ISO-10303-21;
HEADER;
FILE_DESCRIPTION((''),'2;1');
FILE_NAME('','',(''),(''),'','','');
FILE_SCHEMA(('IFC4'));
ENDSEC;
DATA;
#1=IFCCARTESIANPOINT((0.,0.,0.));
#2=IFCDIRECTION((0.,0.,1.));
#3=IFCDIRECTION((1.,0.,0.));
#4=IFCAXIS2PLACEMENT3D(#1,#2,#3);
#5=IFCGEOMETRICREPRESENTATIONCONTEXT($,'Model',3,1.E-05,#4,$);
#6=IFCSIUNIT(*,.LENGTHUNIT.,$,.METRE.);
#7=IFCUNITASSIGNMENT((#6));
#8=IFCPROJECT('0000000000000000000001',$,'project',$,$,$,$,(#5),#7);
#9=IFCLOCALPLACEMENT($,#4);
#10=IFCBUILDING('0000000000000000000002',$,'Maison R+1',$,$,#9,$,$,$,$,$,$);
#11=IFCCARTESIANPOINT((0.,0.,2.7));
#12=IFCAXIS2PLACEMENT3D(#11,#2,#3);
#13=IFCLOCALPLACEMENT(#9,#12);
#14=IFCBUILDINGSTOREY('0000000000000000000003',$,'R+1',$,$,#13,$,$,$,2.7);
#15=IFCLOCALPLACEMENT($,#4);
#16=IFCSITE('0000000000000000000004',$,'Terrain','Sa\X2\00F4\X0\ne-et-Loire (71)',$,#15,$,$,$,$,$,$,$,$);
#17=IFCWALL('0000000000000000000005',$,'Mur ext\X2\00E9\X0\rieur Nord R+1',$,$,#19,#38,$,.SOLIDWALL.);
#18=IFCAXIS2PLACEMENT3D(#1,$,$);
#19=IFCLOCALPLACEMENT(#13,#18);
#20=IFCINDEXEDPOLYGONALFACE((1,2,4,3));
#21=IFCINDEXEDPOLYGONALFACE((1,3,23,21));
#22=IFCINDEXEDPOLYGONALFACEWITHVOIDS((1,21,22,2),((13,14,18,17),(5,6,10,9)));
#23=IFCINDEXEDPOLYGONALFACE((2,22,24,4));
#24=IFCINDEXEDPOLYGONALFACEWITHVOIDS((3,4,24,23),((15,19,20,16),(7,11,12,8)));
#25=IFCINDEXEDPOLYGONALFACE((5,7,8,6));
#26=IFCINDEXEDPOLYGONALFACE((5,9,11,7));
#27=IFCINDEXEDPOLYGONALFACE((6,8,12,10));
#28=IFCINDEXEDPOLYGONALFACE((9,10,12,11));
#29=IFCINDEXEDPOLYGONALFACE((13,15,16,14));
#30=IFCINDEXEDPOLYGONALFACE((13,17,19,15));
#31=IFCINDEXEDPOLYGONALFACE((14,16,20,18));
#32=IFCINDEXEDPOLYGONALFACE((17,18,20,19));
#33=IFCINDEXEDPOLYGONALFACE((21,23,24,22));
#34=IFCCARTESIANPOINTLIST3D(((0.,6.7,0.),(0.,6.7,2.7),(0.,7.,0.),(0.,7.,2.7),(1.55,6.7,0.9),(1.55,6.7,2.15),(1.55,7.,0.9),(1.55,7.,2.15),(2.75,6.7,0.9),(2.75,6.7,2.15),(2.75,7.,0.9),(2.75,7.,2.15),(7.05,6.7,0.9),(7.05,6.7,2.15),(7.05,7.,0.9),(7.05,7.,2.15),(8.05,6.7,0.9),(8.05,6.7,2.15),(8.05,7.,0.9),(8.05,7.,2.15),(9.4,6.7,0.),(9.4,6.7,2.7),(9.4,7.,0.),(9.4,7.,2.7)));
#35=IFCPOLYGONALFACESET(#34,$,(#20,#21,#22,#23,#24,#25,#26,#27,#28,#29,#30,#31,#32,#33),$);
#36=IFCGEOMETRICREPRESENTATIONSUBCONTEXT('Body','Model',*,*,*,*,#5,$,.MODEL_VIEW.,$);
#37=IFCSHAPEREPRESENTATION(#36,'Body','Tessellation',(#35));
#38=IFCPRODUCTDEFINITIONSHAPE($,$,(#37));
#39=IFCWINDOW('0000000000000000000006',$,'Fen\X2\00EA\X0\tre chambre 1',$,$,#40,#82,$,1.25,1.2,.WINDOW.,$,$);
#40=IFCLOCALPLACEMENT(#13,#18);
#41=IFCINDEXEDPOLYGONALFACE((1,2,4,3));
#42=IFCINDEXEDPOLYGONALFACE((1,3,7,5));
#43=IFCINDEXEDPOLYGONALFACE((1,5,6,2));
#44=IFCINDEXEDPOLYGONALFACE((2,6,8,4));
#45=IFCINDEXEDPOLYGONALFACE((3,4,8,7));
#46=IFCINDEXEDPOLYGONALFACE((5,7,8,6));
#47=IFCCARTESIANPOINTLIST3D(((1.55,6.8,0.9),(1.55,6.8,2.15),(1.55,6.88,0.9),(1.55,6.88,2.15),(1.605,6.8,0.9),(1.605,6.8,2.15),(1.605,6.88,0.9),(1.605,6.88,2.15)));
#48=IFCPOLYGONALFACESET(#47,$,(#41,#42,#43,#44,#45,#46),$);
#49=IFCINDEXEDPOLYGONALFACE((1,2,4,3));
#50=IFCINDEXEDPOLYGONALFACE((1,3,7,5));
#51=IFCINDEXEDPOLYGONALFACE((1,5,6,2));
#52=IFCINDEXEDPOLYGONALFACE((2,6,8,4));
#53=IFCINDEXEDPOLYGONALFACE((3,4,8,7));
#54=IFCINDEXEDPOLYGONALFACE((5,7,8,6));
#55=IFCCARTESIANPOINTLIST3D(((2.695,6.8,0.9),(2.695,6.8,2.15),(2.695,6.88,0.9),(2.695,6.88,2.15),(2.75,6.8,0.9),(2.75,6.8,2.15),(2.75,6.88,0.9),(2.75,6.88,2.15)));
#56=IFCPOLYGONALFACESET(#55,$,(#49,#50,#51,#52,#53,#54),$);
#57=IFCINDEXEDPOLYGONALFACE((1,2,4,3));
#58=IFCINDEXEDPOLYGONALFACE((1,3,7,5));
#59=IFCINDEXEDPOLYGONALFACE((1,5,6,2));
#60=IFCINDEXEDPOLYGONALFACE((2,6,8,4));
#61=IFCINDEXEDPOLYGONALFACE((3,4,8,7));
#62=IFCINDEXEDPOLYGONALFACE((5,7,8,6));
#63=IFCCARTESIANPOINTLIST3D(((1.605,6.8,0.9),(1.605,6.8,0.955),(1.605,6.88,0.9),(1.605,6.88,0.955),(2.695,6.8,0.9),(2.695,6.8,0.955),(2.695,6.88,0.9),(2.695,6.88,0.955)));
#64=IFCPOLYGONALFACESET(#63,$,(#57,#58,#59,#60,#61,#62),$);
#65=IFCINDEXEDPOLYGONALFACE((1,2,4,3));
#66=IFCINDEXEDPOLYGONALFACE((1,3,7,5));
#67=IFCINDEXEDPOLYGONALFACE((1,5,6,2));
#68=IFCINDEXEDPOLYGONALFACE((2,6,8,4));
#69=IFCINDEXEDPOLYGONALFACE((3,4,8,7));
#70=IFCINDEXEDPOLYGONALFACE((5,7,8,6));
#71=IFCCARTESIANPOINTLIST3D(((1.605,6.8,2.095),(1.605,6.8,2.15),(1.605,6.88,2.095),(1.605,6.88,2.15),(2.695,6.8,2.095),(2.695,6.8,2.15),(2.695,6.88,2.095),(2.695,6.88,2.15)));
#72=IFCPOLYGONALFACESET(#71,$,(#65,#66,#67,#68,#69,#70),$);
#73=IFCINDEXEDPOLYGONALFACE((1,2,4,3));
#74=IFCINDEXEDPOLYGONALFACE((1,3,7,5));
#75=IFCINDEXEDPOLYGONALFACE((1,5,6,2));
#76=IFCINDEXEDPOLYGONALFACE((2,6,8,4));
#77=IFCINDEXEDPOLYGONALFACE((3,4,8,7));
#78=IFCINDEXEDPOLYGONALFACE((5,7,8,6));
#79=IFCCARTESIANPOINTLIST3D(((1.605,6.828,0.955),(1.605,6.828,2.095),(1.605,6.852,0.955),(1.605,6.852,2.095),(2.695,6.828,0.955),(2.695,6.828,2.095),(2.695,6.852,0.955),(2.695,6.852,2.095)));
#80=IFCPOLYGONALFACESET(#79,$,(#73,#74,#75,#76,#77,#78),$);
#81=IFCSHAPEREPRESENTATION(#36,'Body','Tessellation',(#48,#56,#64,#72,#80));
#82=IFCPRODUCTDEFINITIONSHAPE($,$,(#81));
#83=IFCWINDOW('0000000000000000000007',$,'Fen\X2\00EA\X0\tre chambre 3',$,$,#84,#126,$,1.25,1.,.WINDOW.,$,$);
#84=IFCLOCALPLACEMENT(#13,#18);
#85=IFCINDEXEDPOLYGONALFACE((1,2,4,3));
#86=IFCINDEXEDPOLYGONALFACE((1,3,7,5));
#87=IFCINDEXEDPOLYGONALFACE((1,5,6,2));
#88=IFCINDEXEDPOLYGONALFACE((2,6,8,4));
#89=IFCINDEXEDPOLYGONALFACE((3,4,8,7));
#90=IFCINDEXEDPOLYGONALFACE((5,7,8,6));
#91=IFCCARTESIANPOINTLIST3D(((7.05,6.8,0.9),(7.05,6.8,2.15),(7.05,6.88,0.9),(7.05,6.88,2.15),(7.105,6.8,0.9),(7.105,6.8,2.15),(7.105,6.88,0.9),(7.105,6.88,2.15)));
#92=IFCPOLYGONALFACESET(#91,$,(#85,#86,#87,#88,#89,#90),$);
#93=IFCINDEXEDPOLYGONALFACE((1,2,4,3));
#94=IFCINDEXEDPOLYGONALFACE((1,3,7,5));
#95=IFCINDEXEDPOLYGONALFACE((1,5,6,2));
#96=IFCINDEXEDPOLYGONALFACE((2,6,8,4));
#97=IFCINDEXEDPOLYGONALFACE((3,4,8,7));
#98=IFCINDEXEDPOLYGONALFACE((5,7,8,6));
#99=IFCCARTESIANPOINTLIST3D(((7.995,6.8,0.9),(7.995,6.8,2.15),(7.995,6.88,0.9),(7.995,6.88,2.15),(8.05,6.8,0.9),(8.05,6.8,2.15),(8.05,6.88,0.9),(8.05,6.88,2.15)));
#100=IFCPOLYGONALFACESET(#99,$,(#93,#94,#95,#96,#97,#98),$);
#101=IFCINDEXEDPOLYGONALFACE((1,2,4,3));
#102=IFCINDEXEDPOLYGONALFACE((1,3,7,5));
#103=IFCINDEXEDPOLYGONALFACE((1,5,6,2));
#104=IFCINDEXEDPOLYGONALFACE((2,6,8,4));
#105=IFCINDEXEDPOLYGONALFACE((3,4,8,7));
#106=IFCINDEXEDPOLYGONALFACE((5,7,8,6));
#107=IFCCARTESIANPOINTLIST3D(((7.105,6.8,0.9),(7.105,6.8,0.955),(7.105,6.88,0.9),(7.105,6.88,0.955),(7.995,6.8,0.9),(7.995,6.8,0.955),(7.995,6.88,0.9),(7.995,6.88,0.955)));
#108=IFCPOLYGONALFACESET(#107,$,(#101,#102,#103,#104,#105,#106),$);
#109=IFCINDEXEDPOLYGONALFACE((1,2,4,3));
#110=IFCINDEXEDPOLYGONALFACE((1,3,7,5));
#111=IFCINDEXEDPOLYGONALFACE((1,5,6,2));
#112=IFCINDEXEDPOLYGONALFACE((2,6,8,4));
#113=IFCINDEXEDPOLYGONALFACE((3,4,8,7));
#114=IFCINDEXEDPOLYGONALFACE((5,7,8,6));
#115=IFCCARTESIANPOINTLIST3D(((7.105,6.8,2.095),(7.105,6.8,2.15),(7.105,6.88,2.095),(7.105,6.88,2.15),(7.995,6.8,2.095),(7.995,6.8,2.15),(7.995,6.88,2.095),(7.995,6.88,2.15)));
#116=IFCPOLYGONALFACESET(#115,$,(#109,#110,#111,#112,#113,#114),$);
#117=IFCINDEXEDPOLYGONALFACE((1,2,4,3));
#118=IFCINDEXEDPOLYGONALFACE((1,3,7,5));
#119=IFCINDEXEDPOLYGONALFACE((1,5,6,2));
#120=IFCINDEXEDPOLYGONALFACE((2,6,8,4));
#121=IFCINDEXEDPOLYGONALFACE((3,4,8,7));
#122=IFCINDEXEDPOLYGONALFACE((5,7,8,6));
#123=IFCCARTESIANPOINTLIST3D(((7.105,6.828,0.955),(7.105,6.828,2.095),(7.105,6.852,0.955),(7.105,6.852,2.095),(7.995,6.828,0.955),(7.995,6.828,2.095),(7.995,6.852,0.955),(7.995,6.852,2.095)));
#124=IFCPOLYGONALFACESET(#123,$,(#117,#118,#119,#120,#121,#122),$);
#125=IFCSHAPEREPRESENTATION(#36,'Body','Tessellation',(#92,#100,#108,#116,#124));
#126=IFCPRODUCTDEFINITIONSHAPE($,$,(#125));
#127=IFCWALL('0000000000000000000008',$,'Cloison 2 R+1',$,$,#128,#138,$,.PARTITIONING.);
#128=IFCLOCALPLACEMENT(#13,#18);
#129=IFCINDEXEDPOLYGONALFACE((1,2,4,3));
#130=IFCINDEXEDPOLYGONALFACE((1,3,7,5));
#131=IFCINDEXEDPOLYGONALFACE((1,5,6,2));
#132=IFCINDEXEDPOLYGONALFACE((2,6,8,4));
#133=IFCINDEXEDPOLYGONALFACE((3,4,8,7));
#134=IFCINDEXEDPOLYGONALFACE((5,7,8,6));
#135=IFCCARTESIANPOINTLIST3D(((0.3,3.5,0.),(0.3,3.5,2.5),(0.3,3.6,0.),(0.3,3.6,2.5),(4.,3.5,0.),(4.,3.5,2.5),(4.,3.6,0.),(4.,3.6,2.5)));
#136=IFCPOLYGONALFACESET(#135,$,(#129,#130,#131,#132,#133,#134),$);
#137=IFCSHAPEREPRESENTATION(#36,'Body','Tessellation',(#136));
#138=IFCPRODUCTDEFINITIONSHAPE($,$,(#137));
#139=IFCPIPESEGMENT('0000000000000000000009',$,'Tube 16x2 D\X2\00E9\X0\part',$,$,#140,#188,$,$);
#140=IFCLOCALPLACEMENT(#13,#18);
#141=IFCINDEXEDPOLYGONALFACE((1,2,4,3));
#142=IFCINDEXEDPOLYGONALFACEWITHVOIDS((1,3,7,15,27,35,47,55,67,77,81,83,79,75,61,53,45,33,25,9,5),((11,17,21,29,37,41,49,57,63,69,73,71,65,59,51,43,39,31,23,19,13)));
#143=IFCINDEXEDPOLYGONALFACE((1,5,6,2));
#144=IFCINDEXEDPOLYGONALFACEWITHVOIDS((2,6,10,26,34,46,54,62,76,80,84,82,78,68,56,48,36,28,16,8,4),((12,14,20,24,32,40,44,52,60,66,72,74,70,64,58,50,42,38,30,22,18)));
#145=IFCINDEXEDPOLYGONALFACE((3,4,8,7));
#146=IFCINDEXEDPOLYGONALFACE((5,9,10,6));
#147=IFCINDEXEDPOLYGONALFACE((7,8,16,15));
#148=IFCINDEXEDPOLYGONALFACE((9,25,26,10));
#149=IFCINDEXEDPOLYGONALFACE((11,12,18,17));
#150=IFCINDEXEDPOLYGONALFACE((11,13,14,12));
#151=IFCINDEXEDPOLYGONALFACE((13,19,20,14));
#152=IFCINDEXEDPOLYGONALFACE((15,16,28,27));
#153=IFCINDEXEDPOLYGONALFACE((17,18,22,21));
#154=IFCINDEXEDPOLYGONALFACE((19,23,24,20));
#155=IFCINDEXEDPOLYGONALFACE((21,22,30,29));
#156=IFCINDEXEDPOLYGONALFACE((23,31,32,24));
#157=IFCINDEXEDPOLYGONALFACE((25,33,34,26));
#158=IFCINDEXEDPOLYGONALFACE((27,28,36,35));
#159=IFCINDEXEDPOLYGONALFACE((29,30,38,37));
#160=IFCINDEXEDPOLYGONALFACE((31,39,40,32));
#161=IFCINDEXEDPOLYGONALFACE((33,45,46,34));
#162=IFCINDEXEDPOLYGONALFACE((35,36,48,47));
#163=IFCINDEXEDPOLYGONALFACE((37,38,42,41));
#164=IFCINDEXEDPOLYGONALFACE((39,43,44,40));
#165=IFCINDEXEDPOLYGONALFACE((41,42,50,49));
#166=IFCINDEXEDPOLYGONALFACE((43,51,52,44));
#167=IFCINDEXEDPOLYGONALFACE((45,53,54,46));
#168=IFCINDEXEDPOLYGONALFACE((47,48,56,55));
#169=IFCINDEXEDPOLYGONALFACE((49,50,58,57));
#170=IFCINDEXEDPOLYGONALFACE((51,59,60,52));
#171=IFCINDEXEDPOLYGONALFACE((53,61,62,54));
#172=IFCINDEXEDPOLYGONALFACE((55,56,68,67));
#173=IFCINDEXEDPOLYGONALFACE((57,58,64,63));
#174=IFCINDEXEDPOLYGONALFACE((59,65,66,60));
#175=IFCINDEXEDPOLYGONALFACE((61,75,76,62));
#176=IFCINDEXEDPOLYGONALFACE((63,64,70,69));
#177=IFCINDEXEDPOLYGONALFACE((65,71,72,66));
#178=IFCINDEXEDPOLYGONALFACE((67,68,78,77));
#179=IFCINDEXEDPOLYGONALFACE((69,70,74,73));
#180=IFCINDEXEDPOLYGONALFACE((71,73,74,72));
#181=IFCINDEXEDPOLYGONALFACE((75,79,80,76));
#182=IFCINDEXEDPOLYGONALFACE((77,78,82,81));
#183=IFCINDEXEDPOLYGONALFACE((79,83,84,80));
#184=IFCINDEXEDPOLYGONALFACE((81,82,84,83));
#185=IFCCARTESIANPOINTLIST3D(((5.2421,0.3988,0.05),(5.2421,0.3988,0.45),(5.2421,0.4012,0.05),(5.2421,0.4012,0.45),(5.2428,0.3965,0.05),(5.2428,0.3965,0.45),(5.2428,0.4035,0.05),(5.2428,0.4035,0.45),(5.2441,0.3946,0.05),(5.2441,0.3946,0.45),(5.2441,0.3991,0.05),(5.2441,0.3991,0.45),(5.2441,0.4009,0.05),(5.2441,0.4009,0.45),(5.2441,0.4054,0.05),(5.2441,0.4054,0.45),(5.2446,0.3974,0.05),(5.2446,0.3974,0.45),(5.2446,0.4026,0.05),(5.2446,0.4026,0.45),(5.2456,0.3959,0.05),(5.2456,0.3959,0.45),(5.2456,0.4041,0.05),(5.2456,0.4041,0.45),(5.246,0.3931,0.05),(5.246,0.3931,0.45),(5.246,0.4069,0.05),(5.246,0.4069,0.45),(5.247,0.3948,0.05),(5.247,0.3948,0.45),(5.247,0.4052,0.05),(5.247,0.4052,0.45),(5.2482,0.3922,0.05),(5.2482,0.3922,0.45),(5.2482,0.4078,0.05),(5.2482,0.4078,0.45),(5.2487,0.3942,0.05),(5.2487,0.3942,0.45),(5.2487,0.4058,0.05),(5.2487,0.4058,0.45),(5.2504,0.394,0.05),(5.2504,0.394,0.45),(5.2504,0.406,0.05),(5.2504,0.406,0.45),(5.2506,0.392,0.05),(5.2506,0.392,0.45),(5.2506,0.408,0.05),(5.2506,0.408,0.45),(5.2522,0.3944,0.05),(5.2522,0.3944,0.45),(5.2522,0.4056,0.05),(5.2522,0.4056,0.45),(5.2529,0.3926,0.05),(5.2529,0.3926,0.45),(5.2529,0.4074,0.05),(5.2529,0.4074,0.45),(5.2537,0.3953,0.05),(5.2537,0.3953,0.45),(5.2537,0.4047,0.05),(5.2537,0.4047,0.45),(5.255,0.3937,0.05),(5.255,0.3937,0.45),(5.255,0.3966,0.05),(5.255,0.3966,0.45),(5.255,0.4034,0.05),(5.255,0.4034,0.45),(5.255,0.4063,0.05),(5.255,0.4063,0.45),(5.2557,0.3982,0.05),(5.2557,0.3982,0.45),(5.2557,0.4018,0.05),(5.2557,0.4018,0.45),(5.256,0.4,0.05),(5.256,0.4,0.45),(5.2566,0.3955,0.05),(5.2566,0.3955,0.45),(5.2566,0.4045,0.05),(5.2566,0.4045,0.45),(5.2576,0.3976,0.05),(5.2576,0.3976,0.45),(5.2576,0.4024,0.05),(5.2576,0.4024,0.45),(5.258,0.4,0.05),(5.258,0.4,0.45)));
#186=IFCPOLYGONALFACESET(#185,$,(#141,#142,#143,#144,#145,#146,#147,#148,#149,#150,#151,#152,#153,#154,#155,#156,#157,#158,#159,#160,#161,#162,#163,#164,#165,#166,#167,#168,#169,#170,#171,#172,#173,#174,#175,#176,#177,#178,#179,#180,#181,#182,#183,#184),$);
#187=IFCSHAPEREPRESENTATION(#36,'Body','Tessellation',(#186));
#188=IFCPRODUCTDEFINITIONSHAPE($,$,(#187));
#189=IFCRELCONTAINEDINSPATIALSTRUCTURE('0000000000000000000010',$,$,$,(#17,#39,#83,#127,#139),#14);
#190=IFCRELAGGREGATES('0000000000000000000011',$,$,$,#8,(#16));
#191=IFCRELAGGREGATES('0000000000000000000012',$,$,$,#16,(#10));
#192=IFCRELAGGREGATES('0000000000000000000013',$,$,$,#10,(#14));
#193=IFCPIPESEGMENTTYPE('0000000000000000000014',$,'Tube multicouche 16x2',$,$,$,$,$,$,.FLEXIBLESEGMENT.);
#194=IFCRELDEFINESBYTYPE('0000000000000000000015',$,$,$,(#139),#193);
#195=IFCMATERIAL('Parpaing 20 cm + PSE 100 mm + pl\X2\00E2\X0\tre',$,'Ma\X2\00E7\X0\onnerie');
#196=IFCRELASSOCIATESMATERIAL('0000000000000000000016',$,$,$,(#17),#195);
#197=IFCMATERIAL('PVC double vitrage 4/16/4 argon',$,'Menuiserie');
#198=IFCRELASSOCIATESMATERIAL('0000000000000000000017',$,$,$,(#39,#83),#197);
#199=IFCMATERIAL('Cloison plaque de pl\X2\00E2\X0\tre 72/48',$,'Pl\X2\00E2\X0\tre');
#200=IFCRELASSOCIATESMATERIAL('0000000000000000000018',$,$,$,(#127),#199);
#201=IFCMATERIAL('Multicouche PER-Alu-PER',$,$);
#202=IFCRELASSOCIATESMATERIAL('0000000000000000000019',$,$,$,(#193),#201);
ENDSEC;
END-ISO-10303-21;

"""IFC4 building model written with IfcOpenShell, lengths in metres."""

from ifc_helpers import new_model, si_unit, frame, frame_2d, origin_with_axes, place, context, subcontext, project, spatial, rectangle, hollow_circle, extrude, material, type_object, element, fill, save


model = new_model("IFC4")

# Units and contexts
model_context = context("Model", 3, precision=1e-05, world=origin_with_axes())
body_context = subcontext(model_context, "Body", "Model", "MODEL_VIEW")
ifc_project = project(units=[si_unit("LENGTHUNIT", "METRE")], contexts=[model_context])

# Site, building, storey
site_placement = place(None, origin_with_axes())
site = spatial("IfcSite", under=ifc_project, at=site_placement, Name="Terrain", Description="Saône-et-Loire (71)")
building_placement = place(None, origin_with_axes())
building = spatial("IfcBuilding", under=site, at=building_placement, Name="Maison R+1")
storey_placement = place(building_placement, frame((0.0, 0.0, 2.7), z_axis=(0.0, 0.0, 1.0), x_axis=(1.0, 0.0, 0.0)))
storey = spatial("IfcBuildingStorey", under=building, at=storey_placement, Name="R+1", Elevation=2.7)

# Wall, openings, windows
ifc_material_1 = material(Name="Parpaing 20 cm + PSE 100 mm + plâtre", Category="Maçonnerie")
wall_1_placement = place(storey_placement, frame((0.0, 6.7, 0.0), z_axis=(0.0, 0.0, 1.0), x_axis=(1.0, 0.0, 0.0)))
wall_1 = element("IfcWall", 1, at=wall_1_placement, inside=storey, material=ifc_material_1, Name="Mur extérieur Nord R+1", PredefinedType="SOLIDWALL", context=body_context, shape_type="SweptSolid", body=[
    extrude(rectangle(XDim=9.4, YDim=0.3, at=frame_2d((4.7, 0.15))), origin_with_axes(), (0.0, 0.0, 1.0), 2.7),
])
opening_1_placement = place(storey_placement, frame((1.55, 6.65, 0.9), z_axis=(0.0, 0.0, 1.0), x_axis=(1.0, 0.0, 0.0)))
opening_1 = element("IfcOpeningElement", 2, at=opening_1_placement, cuts=wall_1, context=body_context, shape_type="SweptSolid", body=[
    extrude(rectangle(XDim=1.2, YDim=0.4, at=frame_2d((0.6, 0.2))), origin_with_axes(), (0.0, 0.0, 1.0), 1.25),
])
opening_2_placement = place(storey_placement, frame((7.05, 6.65, 0.9), z_axis=(0.0, 0.0, 1.0), x_axis=(1.0, 0.0, 0.0)))
opening_2 = element("IfcOpeningElement", 3, at=opening_2_placement, cuts=wall_1, context=body_context, shape_type="SweptSolid", body=[
    extrude(rectangle(XDim=1.0, YDim=0.4, at=frame_2d((0.5, 0.2))), origin_with_axes(), (0.0, 0.0, 1.0), 1.25),
])
ifc_material_2 = material(Name="PVC double vitrage 4/16/4 argon", Category="Menuiserie")
window_1_placement = place(storey_placement, frame((1.55, 6.8, 0.9), z_axis=(0.0, 0.0, 1.0), x_axis=(1.0, 0.0, 0.0)))
window_1 = element("IfcWindow", 4, at=window_1_placement, inside=storey, material=ifc_material_2, Name="Fenêtre chambre 1", OverallHeight=1.25, OverallWidth=1.2, PredefinedType="WINDOW", context=body_context, shape_type="SweptSolid", body=[
    extrude(rectangle(XDim=0.055, YDim=0.08, at=frame_2d((0.0275, 0.04))), origin_with_axes(), (0.0, 0.0, 1.0), 1.25),
    extrude(rectangle(XDim=0.055, YDim=0.08, at=frame_2d((0.0275, 0.04))), frame((1.145, 0.0, 0.0), z_axis=(0.0, 0.0, 1.0), x_axis=(1.0, 0.0, 0.0)), (0.0, 0.0, 1.0), 1.25),
    extrude(rectangle(XDim=1.09, YDim=0.08, at=frame_2d((0.545, 0.04))), frame((0.055, 0.0, 0.0), z_axis=(0.0, 0.0, 1.0), x_axis=(1.0, 0.0, 0.0)), (0.0, 0.0, 1.0), 0.055),
    extrude(rectangle(XDim=1.09, YDim=0.08, at=frame_2d((0.545, 0.04))), frame((0.055, 0.0, 1.195), z_axis=(0.0, 0.0, 1.0), x_axis=(1.0, 0.0, 0.0)), (0.0, 0.0, 1.0), 0.055),
    extrude(rectangle(XDim=1.09, YDim=0.024, at=frame_2d((0.545, 0.012))), frame((0.055, 0.028, 0.055), z_axis=(0.0, 0.0, 1.0), x_axis=(1.0, 0.0, 0.0)), (0.0, 0.0, 1.0), 1.14),
])
fill(opening_1, window_1)
window_2_placement = place(storey_placement, frame((7.05, 6.8, 0.9), z_axis=(0.0, 0.0, 1.0), x_axis=(1.0, 0.0, 0.0)))
window_2 = element("IfcWindow", 5, at=window_2_placement, inside=storey, material=ifc_material_2, Name="Fenêtre chambre 3", OverallHeight=1.25, OverallWidth=1.0, PredefinedType="WINDOW", context=body_context, shape_type="SweptSolid", body=[
    extrude(rectangle(XDim=0.055, YDim=0.08, at=frame_2d((0.0275, 0.04))), origin_with_axes(), (0.0, 0.0, 1.0), 1.25),
    extrude(rectangle(XDim=0.055, YDim=0.08, at=frame_2d((0.0275, 0.04))), frame((0.945, 0.0, 0.0), z_axis=(0.0, 0.0, 1.0), x_axis=(1.0, 0.0, 0.0)), (0.0, 0.0, 1.0), 1.25),
    extrude(rectangle(XDim=0.89, YDim=0.08, at=frame_2d((0.445, 0.04))), frame((0.055, 0.0, 0.0), z_axis=(0.0, 0.0, 1.0), x_axis=(1.0, 0.0, 0.0)), (0.0, 0.0, 1.0), 0.055),
    extrude(rectangle(XDim=0.89, YDim=0.08, at=frame_2d((0.445, 0.04))), frame((0.055, 0.0, 1.195), z_axis=(0.0, 0.0, 1.0), x_axis=(1.0, 0.0, 0.0)), (0.0, 0.0, 1.0), 0.055),
    extrude(rectangle(XDim=0.89, YDim=0.024, at=frame_2d((0.445, 0.012))), frame((0.055, 0.028, 0.055), z_axis=(0.0, 0.0, 1.0), x_axis=(1.0, 0.0, 0.0)), (0.0, 0.0, 1.0), 1.14),
])
fill(opening_2, window_2)

# Wall
ifc_material_3 = material(Name="Cloison plaque de plâtre 72/48", Category="Plâtre")
wall_2_placement = place(storey_placement, frame((0.3, 3.5, 0.0), z_axis=(0.0, 0.0, 1.0), x_axis=(1.0, 0.0, 0.0)))
element("IfcWall", 6, at=wall_2_placement, inside=storey, material=ifc_material_3, Name="Cloison 2 R+1", PredefinedType="PARTITIONING", context=body_context, shape_type="SweptSolid", body=[
    extrude(rectangle(XDim=3.7, YDim=0.1, at=frame_2d((1.85, 0.05))), origin_with_axes(), (0.0, 0.0, 1.0), 2.5),
])

# Pipe segment
ifc_material_4 = material(Name="Multicouche PER-Alu-PER")
pipe_segment_type = type_object("IfcPipeSegmentType", Name="Tube multicouche 16x2", PredefinedType="FLEXIBLESEGMENT", material=ifc_material_4)
pipe_segment_1_placement = place(storey_placement, frame((5.25, 0.4, 0.05), z_axis=(0.0, 0.0, 1.0), x_axis=(1.0, 0.0, 0.0)))
element("IfcPipeSegment", 7, at=pipe_segment_1_placement, inside=storey, type_object=pipe_segment_type, Name="Tube 16x2 Départ", context=body_context, shape_type="SweptSolid", body=[
    extrude(hollow_circle(Radius=0.008, WallThickness=0.002), origin_with_axes(), (0.0, 0.0, 1.0), 0.4),
])

save(model, "model.ifc")
